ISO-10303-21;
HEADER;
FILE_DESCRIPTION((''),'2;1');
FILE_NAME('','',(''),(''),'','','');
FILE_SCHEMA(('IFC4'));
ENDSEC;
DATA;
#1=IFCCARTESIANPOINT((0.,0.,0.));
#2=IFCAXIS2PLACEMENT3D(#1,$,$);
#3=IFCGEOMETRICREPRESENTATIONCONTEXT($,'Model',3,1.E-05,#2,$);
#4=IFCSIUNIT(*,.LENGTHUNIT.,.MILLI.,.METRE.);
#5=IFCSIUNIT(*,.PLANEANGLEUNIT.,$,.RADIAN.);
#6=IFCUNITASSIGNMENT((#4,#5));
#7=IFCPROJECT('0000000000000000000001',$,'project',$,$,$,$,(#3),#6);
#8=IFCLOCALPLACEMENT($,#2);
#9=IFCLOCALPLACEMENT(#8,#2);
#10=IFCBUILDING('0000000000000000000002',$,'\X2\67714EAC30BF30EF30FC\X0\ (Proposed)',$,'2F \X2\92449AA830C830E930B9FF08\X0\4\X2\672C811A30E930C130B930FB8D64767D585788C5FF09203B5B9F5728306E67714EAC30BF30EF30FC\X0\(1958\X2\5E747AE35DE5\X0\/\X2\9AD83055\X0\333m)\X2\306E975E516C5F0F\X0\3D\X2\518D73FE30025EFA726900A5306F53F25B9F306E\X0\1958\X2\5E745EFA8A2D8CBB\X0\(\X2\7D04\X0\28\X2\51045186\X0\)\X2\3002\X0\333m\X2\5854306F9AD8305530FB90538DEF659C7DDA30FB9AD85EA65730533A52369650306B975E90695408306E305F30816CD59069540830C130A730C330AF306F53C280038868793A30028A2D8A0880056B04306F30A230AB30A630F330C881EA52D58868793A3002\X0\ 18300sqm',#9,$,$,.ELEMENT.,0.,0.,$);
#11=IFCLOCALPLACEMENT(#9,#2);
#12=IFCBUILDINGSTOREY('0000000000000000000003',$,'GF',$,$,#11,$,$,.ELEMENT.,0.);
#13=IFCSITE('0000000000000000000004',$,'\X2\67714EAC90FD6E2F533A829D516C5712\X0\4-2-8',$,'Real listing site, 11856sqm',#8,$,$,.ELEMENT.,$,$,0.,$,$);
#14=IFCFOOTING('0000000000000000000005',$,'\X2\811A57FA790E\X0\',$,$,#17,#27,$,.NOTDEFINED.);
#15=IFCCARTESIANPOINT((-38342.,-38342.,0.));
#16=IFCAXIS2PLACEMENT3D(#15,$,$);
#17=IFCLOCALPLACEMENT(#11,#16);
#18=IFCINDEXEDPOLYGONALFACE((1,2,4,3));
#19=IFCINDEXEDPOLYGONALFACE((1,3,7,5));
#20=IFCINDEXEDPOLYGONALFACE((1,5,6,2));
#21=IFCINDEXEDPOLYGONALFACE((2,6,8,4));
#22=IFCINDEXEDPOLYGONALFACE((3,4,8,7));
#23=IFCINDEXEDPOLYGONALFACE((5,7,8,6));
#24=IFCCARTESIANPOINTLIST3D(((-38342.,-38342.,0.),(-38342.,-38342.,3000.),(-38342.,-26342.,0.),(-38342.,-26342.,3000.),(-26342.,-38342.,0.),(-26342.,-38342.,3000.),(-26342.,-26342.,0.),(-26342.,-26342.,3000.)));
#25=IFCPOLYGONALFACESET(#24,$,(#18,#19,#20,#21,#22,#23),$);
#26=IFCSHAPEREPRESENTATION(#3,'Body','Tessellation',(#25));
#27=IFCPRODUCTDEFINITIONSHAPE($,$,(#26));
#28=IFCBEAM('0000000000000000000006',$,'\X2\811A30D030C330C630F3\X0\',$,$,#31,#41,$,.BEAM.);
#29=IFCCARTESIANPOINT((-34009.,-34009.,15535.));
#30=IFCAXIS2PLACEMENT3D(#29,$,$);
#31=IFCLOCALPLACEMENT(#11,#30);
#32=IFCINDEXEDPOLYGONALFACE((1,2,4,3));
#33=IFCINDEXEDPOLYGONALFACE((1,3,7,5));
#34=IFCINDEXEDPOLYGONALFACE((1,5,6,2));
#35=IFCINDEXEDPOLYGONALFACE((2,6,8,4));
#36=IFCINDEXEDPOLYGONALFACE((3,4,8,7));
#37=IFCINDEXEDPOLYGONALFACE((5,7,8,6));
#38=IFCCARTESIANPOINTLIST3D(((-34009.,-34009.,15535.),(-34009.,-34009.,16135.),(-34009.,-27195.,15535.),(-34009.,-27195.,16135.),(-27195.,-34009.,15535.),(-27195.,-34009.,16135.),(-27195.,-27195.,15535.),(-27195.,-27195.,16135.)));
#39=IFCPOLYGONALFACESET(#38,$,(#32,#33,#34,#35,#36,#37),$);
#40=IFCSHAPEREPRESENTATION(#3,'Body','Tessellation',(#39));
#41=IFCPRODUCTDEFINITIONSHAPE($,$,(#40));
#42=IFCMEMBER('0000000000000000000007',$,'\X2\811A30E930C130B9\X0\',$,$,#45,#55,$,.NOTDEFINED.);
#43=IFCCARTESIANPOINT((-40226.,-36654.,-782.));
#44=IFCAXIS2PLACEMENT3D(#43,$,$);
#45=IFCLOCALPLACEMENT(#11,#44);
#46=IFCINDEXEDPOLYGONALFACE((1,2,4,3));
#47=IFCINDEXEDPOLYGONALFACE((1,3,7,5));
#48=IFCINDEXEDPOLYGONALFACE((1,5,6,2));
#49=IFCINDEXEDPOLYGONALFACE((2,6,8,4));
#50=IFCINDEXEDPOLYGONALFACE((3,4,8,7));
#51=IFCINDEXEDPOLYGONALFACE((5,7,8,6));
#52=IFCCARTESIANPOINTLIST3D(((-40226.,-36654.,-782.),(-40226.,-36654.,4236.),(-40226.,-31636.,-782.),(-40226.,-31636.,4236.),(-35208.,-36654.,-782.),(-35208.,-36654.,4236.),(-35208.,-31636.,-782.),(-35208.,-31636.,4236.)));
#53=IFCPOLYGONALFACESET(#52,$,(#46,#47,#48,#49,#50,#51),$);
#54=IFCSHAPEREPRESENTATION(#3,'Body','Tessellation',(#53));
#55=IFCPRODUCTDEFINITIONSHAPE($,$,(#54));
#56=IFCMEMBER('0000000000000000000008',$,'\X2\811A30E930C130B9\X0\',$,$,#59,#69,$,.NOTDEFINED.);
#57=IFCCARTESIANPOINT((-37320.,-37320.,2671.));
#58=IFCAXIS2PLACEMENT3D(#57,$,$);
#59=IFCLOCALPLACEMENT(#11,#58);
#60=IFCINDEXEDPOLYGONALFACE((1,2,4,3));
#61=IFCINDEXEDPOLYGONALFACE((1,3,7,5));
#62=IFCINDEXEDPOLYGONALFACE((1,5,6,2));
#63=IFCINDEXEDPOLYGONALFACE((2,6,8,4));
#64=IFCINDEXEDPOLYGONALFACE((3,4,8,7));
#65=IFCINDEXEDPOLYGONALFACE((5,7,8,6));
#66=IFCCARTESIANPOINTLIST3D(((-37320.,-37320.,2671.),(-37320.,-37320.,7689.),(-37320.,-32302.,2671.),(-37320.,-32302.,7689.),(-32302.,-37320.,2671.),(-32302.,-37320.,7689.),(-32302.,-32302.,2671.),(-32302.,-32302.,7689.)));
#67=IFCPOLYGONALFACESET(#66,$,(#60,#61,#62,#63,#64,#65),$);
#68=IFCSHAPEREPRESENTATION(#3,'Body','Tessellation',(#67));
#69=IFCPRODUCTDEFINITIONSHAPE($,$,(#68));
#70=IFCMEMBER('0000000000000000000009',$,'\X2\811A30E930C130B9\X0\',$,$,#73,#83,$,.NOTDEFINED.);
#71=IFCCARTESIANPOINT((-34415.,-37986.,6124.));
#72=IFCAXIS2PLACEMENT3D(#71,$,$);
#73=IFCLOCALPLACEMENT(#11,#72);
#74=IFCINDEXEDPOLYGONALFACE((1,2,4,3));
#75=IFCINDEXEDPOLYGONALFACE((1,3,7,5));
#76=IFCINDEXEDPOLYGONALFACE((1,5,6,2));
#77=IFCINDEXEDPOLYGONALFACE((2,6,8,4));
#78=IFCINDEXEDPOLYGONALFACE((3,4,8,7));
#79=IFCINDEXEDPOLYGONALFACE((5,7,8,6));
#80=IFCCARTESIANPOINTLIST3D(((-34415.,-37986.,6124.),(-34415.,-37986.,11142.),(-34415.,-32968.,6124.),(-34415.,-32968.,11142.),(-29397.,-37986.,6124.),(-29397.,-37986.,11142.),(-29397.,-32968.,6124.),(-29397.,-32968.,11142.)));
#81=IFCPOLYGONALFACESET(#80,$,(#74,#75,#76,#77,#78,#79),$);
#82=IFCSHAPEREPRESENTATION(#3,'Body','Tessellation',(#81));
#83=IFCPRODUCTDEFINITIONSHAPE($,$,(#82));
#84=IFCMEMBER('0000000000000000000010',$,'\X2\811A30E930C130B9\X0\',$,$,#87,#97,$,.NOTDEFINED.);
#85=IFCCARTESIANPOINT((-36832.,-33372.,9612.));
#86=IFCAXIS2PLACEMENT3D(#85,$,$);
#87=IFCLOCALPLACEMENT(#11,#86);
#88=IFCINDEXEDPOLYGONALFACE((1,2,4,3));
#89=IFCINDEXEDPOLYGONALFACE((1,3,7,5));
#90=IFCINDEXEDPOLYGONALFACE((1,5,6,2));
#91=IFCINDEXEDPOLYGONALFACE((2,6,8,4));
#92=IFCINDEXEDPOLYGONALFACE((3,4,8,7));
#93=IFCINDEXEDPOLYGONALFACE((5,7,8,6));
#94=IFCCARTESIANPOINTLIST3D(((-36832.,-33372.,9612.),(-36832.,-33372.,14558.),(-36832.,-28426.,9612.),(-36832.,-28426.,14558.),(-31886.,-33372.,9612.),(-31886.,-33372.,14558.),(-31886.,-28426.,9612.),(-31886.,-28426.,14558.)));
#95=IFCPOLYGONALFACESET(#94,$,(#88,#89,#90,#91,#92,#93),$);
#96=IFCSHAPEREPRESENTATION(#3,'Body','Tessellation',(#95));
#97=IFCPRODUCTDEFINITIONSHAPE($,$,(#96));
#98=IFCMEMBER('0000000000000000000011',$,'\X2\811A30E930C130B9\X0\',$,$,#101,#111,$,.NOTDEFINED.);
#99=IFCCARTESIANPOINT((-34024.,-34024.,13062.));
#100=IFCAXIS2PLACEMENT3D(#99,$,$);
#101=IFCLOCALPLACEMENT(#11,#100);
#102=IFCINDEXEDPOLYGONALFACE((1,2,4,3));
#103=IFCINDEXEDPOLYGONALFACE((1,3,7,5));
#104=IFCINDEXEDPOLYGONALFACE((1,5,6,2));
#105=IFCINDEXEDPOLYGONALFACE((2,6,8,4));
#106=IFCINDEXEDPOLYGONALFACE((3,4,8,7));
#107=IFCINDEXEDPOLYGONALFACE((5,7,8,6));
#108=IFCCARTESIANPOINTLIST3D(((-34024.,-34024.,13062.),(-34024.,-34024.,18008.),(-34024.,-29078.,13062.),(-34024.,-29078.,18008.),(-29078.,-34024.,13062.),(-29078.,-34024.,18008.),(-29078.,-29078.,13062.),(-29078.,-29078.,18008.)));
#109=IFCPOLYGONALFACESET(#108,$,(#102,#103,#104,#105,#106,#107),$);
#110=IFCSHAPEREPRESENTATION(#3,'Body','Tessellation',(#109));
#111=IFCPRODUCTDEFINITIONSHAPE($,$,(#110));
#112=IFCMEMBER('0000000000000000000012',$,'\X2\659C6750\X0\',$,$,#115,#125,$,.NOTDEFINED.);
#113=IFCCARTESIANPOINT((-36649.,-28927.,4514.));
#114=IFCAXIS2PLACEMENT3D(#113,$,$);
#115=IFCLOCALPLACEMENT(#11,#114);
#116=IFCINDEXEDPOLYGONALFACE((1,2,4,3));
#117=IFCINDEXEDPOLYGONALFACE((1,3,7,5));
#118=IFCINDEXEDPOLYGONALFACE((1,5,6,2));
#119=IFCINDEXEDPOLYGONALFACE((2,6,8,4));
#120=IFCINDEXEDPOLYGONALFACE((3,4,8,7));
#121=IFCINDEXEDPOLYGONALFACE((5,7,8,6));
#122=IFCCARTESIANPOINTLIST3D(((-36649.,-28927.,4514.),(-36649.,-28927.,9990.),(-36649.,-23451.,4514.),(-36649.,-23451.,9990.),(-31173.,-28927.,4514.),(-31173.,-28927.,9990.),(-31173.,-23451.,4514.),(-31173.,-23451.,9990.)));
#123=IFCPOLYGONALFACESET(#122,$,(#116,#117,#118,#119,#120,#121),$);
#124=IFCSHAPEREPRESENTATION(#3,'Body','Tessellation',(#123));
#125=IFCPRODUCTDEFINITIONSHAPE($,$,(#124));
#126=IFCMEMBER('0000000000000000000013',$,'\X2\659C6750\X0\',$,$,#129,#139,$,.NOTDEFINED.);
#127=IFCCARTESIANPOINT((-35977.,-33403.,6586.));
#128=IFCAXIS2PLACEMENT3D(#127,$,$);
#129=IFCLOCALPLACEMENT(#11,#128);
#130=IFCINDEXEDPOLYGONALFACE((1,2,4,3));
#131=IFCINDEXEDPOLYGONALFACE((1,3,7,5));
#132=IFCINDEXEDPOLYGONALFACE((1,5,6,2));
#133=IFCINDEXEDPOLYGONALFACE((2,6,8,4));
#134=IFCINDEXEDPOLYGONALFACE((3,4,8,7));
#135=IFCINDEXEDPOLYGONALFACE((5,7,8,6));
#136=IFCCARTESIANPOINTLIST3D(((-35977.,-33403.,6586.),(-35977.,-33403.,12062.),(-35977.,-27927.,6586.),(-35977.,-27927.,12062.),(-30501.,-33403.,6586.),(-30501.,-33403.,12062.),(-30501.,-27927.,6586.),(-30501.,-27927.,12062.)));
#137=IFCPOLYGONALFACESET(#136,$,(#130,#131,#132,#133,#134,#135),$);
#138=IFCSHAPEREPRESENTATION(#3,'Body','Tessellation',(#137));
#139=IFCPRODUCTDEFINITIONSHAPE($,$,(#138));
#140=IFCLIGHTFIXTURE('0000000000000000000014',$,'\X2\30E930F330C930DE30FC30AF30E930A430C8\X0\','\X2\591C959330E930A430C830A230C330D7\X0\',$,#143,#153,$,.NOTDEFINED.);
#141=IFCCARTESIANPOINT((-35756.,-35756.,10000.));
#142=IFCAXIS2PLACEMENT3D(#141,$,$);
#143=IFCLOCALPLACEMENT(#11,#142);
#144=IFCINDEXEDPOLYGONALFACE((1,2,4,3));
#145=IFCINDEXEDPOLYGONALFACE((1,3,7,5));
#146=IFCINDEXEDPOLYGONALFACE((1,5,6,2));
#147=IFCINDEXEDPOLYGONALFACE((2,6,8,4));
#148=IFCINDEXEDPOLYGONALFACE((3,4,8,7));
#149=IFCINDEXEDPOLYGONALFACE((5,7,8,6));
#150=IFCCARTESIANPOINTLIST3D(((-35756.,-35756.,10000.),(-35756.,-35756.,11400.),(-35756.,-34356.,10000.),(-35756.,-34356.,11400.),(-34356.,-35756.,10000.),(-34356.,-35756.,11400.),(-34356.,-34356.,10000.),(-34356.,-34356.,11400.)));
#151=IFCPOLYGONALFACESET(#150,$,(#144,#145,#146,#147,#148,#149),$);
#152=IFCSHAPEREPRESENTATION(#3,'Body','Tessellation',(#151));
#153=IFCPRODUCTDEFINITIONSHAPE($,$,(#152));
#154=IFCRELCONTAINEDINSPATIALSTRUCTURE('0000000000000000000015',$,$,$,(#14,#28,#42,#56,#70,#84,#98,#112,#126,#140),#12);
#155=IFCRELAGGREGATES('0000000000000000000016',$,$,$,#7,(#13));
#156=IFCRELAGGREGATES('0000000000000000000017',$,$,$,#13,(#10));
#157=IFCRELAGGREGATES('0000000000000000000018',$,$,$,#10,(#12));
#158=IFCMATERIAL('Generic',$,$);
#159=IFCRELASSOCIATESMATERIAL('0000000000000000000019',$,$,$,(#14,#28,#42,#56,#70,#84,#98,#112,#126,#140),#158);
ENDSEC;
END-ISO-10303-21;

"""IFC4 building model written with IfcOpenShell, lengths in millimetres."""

from ifc_helpers import new_model, si_unit, frame, frame_2d, origin, place, context, project, spatial, rectangle, extrude, material, element, save


model = new_model("IFC4")

# Units and contexts
model_context = context("Model", 3, precision=1e-05, world=origin())
ifc_project = project(units=[si_unit("LENGTHUNIT", "METRE", prefix="MILLI"), si_unit("PLANEANGLEUNIT", "RADIAN")], contexts=[model_context])

# Site, building, storey
site_placement = place(None, origin())
site = spatial("IfcSite", under=ifc_project, at=site_placement, Name="東京都港区芝公園4-2-8", ObjectType="Real listing site, 11856sqm", CompositionType="ELEMENT", RefElevation=0.0)
building_placement = place(site_placement, origin())
building = spatial("IfcBuilding", under=site, at=building_placement, Name="東京タワー (Proposed)", ObjectType="2F 鉄骨トラス（4本脚ラチス・赤白塗装）※実在の東京タワー(1958年竣工/高さ333m)の非公式3D再現。建物¥は史実の1958年建設費(約28億円)。333m塔は高さ・道路斜線・高度地区制限に非適合のため法適合チェックは参考表示。設計者欄はアカウント自動表示。 18300sqm", CompositionType="ELEMENT", ElevationOfRefHeight=0.0, ElevationOfTerrain=0.0)
storey_placement = place(building_placement, origin())
storey = spatial("IfcBuildingStorey", under=building, at=storey_placement, Name="GF", CompositionType="ELEMENT", Elevation=0.0)

# Footing
ifc_material_1 = material(Name="Generic")
footing_placement = place(storey_placement, frame((-38342.0, -38342.0, 0.0)))
element("IfcFooting", 1, at=footing_placement, inside=storey, material=ifc_material_1, Name="脚基礎", PredefinedType="NOTDEFINED", context=model_context, shape_type="SweptSolid", body=[
    extrude(rectangle(XDim=12000.0, YDim=12000.0, at=frame_2d((6000.0, 6000.0))), frame((-38342.0, -38342.0, 0.0)), (0.0, 0.0, 1.0), 3000.0),
])

# Beam
beam_1_placement = place(storey_placement, frame((-34009.0, -34009.0, 15535.0)))
element("IfcBeam", 2, at=beam_1_placement, inside=storey, material=ifc_material_1, Name="脚バッテン", PredefinedType="BEAM", context=model_context, shape_type="SweptSolid", body=[
    extrude(rectangle(XDim=6814.0, YDim=6814.0, at=frame_2d((3407.0, 3407.0))), frame((-34009.0, -34009.0, 15535.0)), (0.0, 0.0, 1.0), 600.0),
])

# Members
member_1_placement = place(storey_placement, frame((-40226.0, -36654.0, -782.0)))
element("IfcMember", 3, at=member_1_placement, inside=storey, material=ifc_material_1, Name="脚ラチス", PredefinedType="NOTDEFINED", context=model_context, shape_type="SweptSolid", body=[
    extrude(rectangle(XDim=5018.0, YDim=5018.0, at=frame_2d((2509.0, 2509.0))), frame((-40226.0, -36654.0, -782.0)), (0.0, 0.0, 1.0), 5018.0),
])
member_2_placement = place(storey_placement, frame((-37320.0, -37320.0, 2671.0)))
element("IfcMember", 4, at=member_2_placement, inside=storey, material=ifc_material_1, Name="脚ラチス", PredefinedType="NOTDEFINED", context=model_context, shape_type="SweptSolid", body=[
    extrude(rectangle(XDim=5018.0, YDim=5018.0, at=frame_2d((2509.0, 2509.0))), frame((-37320.0, -37320.0, 2671.0)), (0.0, 0.0, 1.0), 5018.0),
])
member_3_placement = place(storey_placement, frame((-34415.0, -37986.0, 6124.0)))
element("IfcMember", 5, at=member_3_placement, inside=storey, material=ifc_material_1, Name="脚ラチス", PredefinedType="NOTDEFINED", context=model_context, shape_type="SweptSolid", body=[
    extrude(rectangle(XDim=5018.0, YDim=5018.0, at=frame_2d((2509.0, 2509.0))), frame((-34415.0, -37986.0, 6124.0)), (0.0, 0.0, 1.0), 5018.0),
])
member_4_placement = place(storey_placement, frame((-36832.0, -33372.0, 9612.0)))
element("IfcMember", 6, at=member_4_placement, inside=storey, material=ifc_material_1, Name="脚ラチス", PredefinedType="NOTDEFINED", context=model_context, shape_type="SweptSolid", body=[
    extrude(rectangle(XDim=4946.0, YDim=4946.0, at=frame_2d((2473.0, 2473.0))), frame((-36832.0, -33372.0, 9612.0)), (0.0, 0.0, 1.0), 4946.0),
])
member_5_placement = place(storey_placement, frame((-34024.0, -34024.0, 13062.0)))
element("IfcMember", 7, at=member_5_placement, inside=storey, material=ifc_material_1, Name="脚ラチス", PredefinedType="NOTDEFINED", context=model_context, shape_type="SweptSolid", body=[
    extrude(rectangle(XDim=4946.0, YDim=4946.0, at=frame_2d((2473.0, 2473.0))), frame((-34024.0, -34024.0, 13062.0)), (0.0, 0.0, 1.0), 4946.0),
])
member_6_placement = place(storey_placement, frame((-36649.0, -28927.0, 4514.0)))
element("IfcMember", 8, at=member_6_placement, inside=storey, material=ifc_material_1, Name="斜材", PredefinedType="NOTDEFINED", context=model_context, shape_type="SweptSolid", body=[
    extrude(rectangle(XDim=5476.0, YDim=5476.0, at=frame_2d((2738.0, 2738.0))), frame((-36649.0, -28927.0, 4514.0)), (0.0, 0.0, 1.0), 5476.0),
])
member_7_placement = place(storey_placement, frame((-35977.0, -33403.0, 6586.0)))
element("IfcMember", 9, at=member_7_placement, inside=storey, material=ifc_material_1, Name="斜材", PredefinedType="NOTDEFINED", context=model_context, shape_type="SweptSolid", body=[
    extrude(rectangle(XDim=5476.0, YDim=5476.0, at=frame_2d((2738.0, 2738.0))), frame((-35977.0, -33403.0, 6586.0)), (0.0, 0.0, 1.0), 5476.0),
])

# Light fixture
light_fixture_placement = place(storey_placement, frame((-35756.0, -35756.0, 10000.0)))
element("IfcLightFixture", 10, at=light_fixture_placement, inside=storey, material=ifc_material_1, Name="ランドマークライト", Description="夜間ライトアップ", PredefinedType="NOTDEFINED", context=model_context, shape_type="SweptSolid", body=[
    extrude(rectangle(XDim=1400.0, YDim=1400.0, at=frame_2d((700.0, 700.0))), frame((-35756.0, -35756.0, 10000.0)), (0.0, 0.0, 1.0), 1400.0),
])

save(model, "model.ifc")
